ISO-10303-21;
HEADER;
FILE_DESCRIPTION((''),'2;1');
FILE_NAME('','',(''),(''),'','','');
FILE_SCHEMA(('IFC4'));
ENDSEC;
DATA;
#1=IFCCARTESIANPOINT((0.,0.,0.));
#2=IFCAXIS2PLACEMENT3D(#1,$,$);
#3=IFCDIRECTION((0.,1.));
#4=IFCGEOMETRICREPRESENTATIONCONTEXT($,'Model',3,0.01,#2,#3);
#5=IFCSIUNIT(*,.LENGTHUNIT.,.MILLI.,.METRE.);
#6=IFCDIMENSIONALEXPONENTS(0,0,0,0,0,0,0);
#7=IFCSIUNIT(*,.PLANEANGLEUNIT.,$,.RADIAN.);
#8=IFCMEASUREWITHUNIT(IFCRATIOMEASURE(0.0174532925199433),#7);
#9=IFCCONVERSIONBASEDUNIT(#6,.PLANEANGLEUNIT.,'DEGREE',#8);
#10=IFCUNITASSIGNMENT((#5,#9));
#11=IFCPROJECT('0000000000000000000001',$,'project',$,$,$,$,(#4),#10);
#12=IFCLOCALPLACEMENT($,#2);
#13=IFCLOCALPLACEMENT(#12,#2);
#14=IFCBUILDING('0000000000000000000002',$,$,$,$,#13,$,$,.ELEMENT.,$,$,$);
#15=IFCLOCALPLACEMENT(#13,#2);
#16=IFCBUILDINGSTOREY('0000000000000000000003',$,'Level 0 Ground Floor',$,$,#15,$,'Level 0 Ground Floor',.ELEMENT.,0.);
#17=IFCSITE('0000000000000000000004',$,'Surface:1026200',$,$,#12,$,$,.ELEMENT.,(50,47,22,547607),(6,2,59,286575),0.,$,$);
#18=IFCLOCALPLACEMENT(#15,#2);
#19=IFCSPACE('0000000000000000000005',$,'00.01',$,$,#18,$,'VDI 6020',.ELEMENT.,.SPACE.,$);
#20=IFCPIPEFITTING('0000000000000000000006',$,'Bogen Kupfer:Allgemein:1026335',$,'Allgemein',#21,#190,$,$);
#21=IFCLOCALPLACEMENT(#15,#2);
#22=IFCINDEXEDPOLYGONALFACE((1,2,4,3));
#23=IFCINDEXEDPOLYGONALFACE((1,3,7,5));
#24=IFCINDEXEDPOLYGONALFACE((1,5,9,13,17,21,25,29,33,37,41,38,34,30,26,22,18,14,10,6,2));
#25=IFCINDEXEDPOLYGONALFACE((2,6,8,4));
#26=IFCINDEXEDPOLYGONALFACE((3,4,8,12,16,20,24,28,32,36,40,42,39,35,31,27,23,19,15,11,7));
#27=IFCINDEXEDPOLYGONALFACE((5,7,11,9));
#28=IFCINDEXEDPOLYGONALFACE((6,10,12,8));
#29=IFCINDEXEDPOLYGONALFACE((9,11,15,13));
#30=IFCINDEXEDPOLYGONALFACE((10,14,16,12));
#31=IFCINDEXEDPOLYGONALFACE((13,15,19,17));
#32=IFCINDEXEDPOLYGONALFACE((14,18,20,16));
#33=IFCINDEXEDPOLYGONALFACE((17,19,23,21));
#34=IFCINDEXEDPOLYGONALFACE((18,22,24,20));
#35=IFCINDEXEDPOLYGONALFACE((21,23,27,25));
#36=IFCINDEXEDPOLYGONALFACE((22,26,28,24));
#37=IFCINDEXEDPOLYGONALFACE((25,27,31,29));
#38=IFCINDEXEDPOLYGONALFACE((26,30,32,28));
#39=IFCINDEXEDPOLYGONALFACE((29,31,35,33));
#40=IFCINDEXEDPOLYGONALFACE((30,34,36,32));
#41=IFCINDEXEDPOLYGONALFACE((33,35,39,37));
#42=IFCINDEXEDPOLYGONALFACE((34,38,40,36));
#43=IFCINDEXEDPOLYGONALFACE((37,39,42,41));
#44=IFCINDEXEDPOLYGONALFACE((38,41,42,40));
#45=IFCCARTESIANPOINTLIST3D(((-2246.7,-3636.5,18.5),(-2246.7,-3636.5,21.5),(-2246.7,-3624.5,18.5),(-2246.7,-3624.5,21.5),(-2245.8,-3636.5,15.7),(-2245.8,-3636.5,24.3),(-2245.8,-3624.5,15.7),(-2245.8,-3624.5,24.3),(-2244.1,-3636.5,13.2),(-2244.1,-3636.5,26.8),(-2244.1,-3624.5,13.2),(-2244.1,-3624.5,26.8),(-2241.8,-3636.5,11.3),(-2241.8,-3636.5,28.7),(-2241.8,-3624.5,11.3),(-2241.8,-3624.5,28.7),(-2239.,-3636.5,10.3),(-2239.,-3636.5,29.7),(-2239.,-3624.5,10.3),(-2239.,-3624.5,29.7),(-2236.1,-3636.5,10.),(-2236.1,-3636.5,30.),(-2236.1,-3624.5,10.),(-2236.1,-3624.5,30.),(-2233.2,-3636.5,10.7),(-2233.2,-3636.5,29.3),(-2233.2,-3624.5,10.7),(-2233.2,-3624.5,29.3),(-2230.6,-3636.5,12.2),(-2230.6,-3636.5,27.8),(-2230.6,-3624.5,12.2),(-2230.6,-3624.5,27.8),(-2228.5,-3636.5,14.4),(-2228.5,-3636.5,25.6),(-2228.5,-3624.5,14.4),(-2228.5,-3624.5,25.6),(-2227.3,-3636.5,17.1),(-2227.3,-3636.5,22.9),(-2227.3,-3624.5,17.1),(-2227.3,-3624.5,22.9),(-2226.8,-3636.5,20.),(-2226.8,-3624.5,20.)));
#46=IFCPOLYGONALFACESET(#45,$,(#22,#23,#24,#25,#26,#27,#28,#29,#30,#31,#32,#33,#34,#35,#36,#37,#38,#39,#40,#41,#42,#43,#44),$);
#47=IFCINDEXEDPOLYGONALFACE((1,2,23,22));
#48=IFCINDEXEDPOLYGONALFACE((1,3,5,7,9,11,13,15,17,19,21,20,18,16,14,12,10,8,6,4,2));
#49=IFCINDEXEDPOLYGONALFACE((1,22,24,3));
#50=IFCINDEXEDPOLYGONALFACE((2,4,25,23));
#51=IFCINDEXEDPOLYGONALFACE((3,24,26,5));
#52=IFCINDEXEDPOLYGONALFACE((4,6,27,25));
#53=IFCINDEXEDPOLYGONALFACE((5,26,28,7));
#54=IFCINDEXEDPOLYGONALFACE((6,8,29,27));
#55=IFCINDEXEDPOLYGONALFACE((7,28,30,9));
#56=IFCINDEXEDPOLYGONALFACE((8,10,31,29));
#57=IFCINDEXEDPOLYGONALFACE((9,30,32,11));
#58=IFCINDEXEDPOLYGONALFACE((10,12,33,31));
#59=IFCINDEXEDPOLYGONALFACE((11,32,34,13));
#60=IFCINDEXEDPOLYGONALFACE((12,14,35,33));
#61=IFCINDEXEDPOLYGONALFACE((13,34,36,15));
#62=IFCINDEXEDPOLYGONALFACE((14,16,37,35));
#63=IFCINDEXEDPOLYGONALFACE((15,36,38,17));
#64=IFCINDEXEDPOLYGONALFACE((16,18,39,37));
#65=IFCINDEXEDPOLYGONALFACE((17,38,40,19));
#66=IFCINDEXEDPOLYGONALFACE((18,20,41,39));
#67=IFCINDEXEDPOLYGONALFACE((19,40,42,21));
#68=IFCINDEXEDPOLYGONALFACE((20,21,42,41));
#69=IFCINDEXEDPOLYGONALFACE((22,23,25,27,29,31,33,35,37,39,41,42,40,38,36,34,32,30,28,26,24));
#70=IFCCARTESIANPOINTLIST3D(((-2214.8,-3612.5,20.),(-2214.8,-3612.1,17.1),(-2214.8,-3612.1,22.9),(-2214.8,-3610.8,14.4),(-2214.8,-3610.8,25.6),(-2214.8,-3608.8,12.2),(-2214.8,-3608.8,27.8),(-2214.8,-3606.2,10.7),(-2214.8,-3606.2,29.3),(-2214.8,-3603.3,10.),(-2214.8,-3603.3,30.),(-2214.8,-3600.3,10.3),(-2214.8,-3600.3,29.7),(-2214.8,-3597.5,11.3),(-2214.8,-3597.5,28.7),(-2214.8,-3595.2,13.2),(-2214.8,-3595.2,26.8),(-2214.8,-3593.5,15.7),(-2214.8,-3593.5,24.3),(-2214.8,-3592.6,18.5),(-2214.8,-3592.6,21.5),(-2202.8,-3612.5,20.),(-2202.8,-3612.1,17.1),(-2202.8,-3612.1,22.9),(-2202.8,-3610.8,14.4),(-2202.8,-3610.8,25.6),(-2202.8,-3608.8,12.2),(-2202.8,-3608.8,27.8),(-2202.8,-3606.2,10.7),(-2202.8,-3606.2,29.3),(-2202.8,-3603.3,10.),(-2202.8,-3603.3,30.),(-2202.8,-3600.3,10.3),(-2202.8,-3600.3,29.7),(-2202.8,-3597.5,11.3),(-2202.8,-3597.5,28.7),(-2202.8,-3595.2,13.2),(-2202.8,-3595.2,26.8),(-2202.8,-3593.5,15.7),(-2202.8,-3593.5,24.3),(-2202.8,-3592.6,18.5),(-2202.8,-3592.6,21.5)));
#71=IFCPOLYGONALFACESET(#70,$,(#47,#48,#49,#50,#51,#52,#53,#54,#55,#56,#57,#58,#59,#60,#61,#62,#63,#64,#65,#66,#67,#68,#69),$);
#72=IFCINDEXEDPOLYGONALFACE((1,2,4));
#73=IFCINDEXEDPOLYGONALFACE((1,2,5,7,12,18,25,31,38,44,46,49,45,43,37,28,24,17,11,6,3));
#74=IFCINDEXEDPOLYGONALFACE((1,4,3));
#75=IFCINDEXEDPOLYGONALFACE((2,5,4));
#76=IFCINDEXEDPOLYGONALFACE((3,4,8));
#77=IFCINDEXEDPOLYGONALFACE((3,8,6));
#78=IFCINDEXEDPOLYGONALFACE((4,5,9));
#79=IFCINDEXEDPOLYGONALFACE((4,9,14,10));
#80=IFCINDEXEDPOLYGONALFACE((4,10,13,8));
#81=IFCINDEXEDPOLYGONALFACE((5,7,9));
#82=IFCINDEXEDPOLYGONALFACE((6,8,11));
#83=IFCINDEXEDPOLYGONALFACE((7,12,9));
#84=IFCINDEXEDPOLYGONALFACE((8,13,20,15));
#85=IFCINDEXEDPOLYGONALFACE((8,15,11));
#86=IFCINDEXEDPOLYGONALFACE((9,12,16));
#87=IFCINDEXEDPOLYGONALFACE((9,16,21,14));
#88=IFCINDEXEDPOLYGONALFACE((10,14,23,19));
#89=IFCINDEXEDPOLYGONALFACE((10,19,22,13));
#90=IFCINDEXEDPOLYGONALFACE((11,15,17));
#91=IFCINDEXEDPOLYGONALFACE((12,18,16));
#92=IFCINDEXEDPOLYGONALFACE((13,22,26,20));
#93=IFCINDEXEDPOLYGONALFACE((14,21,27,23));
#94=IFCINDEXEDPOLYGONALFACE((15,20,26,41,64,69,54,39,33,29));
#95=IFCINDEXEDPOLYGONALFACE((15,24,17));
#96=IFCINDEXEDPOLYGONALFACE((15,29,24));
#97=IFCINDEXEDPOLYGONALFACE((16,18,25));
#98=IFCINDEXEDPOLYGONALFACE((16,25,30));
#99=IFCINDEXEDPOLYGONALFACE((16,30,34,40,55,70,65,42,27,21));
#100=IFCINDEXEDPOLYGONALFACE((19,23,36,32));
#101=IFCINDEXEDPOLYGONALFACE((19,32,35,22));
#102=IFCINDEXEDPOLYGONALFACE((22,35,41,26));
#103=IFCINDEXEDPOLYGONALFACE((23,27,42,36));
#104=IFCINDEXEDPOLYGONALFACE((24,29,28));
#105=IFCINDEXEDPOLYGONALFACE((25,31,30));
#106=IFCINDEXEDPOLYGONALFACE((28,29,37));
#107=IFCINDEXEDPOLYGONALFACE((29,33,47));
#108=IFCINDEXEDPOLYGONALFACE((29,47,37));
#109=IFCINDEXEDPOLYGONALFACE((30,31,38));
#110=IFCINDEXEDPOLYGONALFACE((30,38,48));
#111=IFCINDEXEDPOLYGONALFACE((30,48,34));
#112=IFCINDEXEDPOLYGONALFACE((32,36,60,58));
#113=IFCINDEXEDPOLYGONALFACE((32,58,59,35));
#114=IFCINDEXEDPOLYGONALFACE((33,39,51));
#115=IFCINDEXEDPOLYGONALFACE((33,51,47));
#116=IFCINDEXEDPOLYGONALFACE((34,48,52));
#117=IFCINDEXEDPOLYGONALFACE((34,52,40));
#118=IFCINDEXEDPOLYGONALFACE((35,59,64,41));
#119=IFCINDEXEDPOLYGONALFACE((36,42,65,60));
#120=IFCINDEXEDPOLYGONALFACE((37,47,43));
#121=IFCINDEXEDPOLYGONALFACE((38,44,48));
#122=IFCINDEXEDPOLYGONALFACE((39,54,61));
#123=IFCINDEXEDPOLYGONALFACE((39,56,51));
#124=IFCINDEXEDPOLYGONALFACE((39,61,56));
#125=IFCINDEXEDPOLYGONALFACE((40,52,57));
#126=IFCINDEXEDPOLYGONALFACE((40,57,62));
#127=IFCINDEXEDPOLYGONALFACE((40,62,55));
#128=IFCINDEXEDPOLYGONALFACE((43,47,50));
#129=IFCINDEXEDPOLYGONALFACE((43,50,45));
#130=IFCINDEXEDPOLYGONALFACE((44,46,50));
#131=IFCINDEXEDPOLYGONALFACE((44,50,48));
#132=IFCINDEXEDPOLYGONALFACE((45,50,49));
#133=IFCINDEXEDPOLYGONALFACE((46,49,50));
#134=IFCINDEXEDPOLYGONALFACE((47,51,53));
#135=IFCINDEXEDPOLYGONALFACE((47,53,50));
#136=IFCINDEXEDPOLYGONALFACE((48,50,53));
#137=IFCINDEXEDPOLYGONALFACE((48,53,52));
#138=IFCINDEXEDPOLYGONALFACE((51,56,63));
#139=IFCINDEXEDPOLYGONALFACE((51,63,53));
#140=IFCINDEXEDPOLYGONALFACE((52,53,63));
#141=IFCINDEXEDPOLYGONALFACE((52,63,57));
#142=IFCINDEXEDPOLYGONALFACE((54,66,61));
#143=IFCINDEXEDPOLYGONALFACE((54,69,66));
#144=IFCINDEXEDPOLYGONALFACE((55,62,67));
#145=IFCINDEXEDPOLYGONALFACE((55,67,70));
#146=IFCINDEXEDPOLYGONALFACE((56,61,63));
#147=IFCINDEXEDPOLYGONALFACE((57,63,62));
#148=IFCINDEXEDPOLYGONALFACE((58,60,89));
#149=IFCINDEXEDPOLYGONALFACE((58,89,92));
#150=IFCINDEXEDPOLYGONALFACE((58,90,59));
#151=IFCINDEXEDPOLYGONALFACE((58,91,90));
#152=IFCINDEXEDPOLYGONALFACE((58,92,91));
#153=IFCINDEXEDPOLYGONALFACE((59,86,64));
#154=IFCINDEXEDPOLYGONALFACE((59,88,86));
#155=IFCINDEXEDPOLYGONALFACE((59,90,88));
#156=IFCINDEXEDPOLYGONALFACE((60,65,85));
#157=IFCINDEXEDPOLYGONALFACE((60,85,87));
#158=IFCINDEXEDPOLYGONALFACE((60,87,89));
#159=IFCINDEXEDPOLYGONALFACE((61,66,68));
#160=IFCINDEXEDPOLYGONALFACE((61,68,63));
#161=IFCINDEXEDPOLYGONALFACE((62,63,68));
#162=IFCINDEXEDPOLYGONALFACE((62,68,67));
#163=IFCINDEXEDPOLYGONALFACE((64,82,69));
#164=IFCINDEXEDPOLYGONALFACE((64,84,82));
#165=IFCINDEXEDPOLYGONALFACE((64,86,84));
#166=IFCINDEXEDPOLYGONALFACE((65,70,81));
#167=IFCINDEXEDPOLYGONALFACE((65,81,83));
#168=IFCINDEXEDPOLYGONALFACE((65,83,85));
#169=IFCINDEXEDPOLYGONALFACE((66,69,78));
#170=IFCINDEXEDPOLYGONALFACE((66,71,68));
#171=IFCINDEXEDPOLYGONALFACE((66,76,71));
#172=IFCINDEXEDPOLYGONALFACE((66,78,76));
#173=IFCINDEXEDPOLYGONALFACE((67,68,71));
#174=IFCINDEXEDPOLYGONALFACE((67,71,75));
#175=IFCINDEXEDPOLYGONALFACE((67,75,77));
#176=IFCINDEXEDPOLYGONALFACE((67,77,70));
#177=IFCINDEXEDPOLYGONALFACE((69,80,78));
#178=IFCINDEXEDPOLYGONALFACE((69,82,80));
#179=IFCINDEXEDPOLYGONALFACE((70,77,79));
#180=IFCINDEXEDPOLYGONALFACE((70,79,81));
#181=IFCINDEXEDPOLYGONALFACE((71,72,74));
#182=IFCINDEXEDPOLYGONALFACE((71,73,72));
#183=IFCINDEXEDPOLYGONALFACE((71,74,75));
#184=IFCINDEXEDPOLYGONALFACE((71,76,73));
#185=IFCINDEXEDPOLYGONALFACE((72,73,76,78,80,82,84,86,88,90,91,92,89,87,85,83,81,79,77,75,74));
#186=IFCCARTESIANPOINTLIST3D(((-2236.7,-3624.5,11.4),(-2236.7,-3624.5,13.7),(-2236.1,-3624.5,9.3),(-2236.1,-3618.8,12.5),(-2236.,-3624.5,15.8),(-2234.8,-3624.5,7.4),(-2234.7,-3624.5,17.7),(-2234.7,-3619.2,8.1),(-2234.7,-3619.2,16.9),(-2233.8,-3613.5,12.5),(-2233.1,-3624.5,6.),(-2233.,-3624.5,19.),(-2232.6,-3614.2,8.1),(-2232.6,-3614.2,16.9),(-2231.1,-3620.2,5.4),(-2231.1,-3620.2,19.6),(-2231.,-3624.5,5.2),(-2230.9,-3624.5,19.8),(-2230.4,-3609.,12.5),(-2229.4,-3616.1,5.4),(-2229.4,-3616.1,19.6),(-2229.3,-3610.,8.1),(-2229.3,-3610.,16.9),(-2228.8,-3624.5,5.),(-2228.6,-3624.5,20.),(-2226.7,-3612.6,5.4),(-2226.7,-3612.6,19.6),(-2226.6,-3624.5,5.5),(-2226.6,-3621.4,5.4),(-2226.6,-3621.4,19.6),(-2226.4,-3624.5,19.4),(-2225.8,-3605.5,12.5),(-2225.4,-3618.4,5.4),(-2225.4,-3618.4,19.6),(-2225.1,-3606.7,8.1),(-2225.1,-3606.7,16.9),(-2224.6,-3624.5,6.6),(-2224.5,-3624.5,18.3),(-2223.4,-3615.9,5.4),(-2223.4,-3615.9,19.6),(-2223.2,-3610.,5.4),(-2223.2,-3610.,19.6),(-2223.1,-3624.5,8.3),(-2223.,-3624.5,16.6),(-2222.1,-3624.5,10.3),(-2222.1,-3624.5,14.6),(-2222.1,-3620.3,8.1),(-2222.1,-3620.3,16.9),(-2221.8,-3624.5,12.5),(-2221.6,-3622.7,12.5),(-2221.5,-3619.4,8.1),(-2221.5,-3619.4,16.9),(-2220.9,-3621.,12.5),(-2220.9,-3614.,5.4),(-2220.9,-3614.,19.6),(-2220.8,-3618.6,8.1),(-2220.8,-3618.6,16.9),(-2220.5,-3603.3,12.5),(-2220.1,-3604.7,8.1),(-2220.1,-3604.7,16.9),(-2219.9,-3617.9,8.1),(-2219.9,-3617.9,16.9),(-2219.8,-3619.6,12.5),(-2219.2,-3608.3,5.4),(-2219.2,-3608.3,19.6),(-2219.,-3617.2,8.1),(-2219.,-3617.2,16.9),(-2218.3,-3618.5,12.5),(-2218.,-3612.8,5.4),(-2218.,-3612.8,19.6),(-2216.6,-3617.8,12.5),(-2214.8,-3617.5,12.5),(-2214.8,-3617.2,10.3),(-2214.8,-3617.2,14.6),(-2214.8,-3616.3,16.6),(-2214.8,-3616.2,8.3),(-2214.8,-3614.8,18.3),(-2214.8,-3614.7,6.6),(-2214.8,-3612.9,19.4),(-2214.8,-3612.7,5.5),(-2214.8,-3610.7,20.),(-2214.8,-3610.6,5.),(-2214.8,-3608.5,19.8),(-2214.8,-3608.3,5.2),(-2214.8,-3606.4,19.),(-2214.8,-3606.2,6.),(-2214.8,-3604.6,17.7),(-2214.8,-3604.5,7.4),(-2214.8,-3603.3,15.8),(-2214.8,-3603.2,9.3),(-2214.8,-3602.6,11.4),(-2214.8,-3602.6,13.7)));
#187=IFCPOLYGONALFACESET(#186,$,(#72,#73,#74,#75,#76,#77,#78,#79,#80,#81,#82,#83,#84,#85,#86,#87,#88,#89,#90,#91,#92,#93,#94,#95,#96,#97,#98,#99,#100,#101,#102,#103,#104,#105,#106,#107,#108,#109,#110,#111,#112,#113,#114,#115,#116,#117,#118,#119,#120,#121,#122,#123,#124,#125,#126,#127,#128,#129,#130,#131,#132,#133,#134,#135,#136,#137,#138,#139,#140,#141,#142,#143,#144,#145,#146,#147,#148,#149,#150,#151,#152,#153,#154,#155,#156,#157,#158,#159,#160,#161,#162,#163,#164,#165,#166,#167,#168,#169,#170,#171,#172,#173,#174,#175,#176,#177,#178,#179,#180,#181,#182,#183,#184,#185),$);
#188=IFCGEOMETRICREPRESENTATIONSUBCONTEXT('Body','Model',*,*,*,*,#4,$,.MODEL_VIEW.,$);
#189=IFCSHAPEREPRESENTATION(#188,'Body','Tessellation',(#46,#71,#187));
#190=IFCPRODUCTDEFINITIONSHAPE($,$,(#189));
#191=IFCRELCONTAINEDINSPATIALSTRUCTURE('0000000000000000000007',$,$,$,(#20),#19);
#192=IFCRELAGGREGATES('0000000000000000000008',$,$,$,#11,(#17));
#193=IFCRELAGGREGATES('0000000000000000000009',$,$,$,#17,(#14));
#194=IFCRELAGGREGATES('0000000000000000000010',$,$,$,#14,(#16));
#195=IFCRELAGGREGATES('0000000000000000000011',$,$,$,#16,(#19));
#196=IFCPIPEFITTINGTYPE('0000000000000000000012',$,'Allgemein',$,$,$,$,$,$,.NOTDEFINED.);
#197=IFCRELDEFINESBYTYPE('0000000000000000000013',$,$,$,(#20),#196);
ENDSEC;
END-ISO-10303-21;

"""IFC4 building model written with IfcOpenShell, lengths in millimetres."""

from ifc_helpers import new_model, entity, si_unit, converted_unit, direction, frame, frame_2d, origin, place, context, subcontext, project, spatial, circle, extrude, source, transform, mapped, type_object, type_shapes, element, save


model = new_model("IFC4")

# Units and contexts
model_context = context("Model", 3, precision=0.01, world=origin(), true_north=direction((0.0, 1.0)))
body_context = subcontext(model_context, "Body", "Model", "MODEL_VIEW")
ifc_project = project(units=[si_unit("LENGTHUNIT", "METRE", prefix="MILLI"), converted_unit("PLANEANGLEUNIT", "DEGREE", entity("IfcRatioMeasure", 0.0174532925199433), si_unit("PLANEANGLEUNIT", "RADIAN"), dimensions=[0, 0, 0, 0, 0, 0, 0])], contexts=[model_context])

# Site, building, storey
site_placement = place(None, origin())
site = spatial("IfcSite", under=ifc_project, at=site_placement, Name="Surface:1026200", CompositionType="ELEMENT", RefLatitude=(50, 47, 22, 547607), RefLongitude=(6, 2, 59, 286575), RefElevation=0.0)
building_placement = place(site_placement, origin())
building = spatial("IfcBuilding", under=site, at=building_placement, CompositionType="ELEMENT")
storey_placement = place(building_placement, origin())
storey = spatial("IfcBuildingStorey", under=building, at=storey_placement, Name="Level 0 Ground Floor", LongName="Level 0 Ground Floor", CompositionType="ELEMENT", Elevation=0.0)

# Shared definitions
pipe_fitting_type = type_object("IfcPipeFittingType", Name="Allgemein", PredefinedType="NOTDEFINED")
ifc_direction = entity("IfcDirection", [0.0, 0.0, -1.0])
trimmed_curve = entity("IfcTrimmedCurve", entity("IfcCircle", entity("IfcAxis2Placement2D", entity("IfcCartesianPoint", [-14.5, 0.0]), entity("IfcDirection", [0.0, 1.0])), 14.5), [entity("IfcParameterValue", 270.0)], [entity("IfcParameterValue", 0.0)], True, "PARAMETER")
shared_shape_1 = source(origin(), body_context, "Body", "SolidModel", [
    extrude(circle(Radius=10.0, at=frame_2d((0.0, 0.0), x_axis=(1.0, 0.0))), frame((0.0, 22.0, 0.0), z_axis=(0.0, 1.0, 0.0), x_axis=(-1.0, 0.0, 0.0)), (0.0, 0.0, 1.0), 12.0),
    extrude(circle(Radius=10.0, at=frame_2d((0.0, 0.0), x_axis=(1.0, 0.0))), frame((-34.0, 0.0, 0.0), z_axis=(1.0, 0.0, 0.0), x_axis=(0.0, 1.0, 0.0)), (0.0, 0.0, 1.0), 12.0),
    entity("IfcSurfaceCurveSweptAreaSolid", entity("IfcCircleProfileDef", "AREA", None, entity("IfcAxis2Placement2D", entity("IfcCartesianPoint", [0.0, 7.5]), entity("IfcDirection", [1.0, 0.0])), 7.5), entity("IfcAxis2Placement3D", entity("IfcCartesianPoint", [-7.5, 22.0, 0.0]), ifc_direction, entity("IfcDirection", [1.0, 0.0, 0.0])), trimmed_curve, 0.0, 90.0, entity("IfcSurfaceOfLinearExtrusion", entity("IfcArbitraryOpenProfileDef", "CURVE", None, trimmed_curve), entity("IfcAxis2Placement3D", entity("IfcCartesianPoint", [0.0, 0.0, -304.8])), ifc_direction, 1.0)),
])
type_shapes(pipe_fitting_type, [shared_shape_1])

# Shared definitions
space_placement = place(storey_placement, origin())
space = spatial("IfcSpace", under=storey, at=space_placement, Name="00.01", LongName="VDI 6020", CompositionType="ELEMENT", PredefinedType="SPACE")

# Pipe fitting
for number, where, z_axis, x_axis, name in (
    (1, (-2236.8, -3602.5, 20.0), (0.0, 0.0, 1.0), (-1.0, 0.0, 0.0), "Bogen Kupfer:Allgemein:1026335"),
):
    element("IfcPipeFitting", number, at=place(space_placement, frame(where, z_axis=z_axis, x_axis=x_axis)), inside=space, type_object=pipe_fitting_type, Name=name, ObjectType="Allgemein", context=body_context, shape_type="MappedRepresentation", body=[
        mapped(shared_shape_1, transform((0.0, 0.0, 0.0), scale=1.0)),
    ])

save(model, "model.ifc")
